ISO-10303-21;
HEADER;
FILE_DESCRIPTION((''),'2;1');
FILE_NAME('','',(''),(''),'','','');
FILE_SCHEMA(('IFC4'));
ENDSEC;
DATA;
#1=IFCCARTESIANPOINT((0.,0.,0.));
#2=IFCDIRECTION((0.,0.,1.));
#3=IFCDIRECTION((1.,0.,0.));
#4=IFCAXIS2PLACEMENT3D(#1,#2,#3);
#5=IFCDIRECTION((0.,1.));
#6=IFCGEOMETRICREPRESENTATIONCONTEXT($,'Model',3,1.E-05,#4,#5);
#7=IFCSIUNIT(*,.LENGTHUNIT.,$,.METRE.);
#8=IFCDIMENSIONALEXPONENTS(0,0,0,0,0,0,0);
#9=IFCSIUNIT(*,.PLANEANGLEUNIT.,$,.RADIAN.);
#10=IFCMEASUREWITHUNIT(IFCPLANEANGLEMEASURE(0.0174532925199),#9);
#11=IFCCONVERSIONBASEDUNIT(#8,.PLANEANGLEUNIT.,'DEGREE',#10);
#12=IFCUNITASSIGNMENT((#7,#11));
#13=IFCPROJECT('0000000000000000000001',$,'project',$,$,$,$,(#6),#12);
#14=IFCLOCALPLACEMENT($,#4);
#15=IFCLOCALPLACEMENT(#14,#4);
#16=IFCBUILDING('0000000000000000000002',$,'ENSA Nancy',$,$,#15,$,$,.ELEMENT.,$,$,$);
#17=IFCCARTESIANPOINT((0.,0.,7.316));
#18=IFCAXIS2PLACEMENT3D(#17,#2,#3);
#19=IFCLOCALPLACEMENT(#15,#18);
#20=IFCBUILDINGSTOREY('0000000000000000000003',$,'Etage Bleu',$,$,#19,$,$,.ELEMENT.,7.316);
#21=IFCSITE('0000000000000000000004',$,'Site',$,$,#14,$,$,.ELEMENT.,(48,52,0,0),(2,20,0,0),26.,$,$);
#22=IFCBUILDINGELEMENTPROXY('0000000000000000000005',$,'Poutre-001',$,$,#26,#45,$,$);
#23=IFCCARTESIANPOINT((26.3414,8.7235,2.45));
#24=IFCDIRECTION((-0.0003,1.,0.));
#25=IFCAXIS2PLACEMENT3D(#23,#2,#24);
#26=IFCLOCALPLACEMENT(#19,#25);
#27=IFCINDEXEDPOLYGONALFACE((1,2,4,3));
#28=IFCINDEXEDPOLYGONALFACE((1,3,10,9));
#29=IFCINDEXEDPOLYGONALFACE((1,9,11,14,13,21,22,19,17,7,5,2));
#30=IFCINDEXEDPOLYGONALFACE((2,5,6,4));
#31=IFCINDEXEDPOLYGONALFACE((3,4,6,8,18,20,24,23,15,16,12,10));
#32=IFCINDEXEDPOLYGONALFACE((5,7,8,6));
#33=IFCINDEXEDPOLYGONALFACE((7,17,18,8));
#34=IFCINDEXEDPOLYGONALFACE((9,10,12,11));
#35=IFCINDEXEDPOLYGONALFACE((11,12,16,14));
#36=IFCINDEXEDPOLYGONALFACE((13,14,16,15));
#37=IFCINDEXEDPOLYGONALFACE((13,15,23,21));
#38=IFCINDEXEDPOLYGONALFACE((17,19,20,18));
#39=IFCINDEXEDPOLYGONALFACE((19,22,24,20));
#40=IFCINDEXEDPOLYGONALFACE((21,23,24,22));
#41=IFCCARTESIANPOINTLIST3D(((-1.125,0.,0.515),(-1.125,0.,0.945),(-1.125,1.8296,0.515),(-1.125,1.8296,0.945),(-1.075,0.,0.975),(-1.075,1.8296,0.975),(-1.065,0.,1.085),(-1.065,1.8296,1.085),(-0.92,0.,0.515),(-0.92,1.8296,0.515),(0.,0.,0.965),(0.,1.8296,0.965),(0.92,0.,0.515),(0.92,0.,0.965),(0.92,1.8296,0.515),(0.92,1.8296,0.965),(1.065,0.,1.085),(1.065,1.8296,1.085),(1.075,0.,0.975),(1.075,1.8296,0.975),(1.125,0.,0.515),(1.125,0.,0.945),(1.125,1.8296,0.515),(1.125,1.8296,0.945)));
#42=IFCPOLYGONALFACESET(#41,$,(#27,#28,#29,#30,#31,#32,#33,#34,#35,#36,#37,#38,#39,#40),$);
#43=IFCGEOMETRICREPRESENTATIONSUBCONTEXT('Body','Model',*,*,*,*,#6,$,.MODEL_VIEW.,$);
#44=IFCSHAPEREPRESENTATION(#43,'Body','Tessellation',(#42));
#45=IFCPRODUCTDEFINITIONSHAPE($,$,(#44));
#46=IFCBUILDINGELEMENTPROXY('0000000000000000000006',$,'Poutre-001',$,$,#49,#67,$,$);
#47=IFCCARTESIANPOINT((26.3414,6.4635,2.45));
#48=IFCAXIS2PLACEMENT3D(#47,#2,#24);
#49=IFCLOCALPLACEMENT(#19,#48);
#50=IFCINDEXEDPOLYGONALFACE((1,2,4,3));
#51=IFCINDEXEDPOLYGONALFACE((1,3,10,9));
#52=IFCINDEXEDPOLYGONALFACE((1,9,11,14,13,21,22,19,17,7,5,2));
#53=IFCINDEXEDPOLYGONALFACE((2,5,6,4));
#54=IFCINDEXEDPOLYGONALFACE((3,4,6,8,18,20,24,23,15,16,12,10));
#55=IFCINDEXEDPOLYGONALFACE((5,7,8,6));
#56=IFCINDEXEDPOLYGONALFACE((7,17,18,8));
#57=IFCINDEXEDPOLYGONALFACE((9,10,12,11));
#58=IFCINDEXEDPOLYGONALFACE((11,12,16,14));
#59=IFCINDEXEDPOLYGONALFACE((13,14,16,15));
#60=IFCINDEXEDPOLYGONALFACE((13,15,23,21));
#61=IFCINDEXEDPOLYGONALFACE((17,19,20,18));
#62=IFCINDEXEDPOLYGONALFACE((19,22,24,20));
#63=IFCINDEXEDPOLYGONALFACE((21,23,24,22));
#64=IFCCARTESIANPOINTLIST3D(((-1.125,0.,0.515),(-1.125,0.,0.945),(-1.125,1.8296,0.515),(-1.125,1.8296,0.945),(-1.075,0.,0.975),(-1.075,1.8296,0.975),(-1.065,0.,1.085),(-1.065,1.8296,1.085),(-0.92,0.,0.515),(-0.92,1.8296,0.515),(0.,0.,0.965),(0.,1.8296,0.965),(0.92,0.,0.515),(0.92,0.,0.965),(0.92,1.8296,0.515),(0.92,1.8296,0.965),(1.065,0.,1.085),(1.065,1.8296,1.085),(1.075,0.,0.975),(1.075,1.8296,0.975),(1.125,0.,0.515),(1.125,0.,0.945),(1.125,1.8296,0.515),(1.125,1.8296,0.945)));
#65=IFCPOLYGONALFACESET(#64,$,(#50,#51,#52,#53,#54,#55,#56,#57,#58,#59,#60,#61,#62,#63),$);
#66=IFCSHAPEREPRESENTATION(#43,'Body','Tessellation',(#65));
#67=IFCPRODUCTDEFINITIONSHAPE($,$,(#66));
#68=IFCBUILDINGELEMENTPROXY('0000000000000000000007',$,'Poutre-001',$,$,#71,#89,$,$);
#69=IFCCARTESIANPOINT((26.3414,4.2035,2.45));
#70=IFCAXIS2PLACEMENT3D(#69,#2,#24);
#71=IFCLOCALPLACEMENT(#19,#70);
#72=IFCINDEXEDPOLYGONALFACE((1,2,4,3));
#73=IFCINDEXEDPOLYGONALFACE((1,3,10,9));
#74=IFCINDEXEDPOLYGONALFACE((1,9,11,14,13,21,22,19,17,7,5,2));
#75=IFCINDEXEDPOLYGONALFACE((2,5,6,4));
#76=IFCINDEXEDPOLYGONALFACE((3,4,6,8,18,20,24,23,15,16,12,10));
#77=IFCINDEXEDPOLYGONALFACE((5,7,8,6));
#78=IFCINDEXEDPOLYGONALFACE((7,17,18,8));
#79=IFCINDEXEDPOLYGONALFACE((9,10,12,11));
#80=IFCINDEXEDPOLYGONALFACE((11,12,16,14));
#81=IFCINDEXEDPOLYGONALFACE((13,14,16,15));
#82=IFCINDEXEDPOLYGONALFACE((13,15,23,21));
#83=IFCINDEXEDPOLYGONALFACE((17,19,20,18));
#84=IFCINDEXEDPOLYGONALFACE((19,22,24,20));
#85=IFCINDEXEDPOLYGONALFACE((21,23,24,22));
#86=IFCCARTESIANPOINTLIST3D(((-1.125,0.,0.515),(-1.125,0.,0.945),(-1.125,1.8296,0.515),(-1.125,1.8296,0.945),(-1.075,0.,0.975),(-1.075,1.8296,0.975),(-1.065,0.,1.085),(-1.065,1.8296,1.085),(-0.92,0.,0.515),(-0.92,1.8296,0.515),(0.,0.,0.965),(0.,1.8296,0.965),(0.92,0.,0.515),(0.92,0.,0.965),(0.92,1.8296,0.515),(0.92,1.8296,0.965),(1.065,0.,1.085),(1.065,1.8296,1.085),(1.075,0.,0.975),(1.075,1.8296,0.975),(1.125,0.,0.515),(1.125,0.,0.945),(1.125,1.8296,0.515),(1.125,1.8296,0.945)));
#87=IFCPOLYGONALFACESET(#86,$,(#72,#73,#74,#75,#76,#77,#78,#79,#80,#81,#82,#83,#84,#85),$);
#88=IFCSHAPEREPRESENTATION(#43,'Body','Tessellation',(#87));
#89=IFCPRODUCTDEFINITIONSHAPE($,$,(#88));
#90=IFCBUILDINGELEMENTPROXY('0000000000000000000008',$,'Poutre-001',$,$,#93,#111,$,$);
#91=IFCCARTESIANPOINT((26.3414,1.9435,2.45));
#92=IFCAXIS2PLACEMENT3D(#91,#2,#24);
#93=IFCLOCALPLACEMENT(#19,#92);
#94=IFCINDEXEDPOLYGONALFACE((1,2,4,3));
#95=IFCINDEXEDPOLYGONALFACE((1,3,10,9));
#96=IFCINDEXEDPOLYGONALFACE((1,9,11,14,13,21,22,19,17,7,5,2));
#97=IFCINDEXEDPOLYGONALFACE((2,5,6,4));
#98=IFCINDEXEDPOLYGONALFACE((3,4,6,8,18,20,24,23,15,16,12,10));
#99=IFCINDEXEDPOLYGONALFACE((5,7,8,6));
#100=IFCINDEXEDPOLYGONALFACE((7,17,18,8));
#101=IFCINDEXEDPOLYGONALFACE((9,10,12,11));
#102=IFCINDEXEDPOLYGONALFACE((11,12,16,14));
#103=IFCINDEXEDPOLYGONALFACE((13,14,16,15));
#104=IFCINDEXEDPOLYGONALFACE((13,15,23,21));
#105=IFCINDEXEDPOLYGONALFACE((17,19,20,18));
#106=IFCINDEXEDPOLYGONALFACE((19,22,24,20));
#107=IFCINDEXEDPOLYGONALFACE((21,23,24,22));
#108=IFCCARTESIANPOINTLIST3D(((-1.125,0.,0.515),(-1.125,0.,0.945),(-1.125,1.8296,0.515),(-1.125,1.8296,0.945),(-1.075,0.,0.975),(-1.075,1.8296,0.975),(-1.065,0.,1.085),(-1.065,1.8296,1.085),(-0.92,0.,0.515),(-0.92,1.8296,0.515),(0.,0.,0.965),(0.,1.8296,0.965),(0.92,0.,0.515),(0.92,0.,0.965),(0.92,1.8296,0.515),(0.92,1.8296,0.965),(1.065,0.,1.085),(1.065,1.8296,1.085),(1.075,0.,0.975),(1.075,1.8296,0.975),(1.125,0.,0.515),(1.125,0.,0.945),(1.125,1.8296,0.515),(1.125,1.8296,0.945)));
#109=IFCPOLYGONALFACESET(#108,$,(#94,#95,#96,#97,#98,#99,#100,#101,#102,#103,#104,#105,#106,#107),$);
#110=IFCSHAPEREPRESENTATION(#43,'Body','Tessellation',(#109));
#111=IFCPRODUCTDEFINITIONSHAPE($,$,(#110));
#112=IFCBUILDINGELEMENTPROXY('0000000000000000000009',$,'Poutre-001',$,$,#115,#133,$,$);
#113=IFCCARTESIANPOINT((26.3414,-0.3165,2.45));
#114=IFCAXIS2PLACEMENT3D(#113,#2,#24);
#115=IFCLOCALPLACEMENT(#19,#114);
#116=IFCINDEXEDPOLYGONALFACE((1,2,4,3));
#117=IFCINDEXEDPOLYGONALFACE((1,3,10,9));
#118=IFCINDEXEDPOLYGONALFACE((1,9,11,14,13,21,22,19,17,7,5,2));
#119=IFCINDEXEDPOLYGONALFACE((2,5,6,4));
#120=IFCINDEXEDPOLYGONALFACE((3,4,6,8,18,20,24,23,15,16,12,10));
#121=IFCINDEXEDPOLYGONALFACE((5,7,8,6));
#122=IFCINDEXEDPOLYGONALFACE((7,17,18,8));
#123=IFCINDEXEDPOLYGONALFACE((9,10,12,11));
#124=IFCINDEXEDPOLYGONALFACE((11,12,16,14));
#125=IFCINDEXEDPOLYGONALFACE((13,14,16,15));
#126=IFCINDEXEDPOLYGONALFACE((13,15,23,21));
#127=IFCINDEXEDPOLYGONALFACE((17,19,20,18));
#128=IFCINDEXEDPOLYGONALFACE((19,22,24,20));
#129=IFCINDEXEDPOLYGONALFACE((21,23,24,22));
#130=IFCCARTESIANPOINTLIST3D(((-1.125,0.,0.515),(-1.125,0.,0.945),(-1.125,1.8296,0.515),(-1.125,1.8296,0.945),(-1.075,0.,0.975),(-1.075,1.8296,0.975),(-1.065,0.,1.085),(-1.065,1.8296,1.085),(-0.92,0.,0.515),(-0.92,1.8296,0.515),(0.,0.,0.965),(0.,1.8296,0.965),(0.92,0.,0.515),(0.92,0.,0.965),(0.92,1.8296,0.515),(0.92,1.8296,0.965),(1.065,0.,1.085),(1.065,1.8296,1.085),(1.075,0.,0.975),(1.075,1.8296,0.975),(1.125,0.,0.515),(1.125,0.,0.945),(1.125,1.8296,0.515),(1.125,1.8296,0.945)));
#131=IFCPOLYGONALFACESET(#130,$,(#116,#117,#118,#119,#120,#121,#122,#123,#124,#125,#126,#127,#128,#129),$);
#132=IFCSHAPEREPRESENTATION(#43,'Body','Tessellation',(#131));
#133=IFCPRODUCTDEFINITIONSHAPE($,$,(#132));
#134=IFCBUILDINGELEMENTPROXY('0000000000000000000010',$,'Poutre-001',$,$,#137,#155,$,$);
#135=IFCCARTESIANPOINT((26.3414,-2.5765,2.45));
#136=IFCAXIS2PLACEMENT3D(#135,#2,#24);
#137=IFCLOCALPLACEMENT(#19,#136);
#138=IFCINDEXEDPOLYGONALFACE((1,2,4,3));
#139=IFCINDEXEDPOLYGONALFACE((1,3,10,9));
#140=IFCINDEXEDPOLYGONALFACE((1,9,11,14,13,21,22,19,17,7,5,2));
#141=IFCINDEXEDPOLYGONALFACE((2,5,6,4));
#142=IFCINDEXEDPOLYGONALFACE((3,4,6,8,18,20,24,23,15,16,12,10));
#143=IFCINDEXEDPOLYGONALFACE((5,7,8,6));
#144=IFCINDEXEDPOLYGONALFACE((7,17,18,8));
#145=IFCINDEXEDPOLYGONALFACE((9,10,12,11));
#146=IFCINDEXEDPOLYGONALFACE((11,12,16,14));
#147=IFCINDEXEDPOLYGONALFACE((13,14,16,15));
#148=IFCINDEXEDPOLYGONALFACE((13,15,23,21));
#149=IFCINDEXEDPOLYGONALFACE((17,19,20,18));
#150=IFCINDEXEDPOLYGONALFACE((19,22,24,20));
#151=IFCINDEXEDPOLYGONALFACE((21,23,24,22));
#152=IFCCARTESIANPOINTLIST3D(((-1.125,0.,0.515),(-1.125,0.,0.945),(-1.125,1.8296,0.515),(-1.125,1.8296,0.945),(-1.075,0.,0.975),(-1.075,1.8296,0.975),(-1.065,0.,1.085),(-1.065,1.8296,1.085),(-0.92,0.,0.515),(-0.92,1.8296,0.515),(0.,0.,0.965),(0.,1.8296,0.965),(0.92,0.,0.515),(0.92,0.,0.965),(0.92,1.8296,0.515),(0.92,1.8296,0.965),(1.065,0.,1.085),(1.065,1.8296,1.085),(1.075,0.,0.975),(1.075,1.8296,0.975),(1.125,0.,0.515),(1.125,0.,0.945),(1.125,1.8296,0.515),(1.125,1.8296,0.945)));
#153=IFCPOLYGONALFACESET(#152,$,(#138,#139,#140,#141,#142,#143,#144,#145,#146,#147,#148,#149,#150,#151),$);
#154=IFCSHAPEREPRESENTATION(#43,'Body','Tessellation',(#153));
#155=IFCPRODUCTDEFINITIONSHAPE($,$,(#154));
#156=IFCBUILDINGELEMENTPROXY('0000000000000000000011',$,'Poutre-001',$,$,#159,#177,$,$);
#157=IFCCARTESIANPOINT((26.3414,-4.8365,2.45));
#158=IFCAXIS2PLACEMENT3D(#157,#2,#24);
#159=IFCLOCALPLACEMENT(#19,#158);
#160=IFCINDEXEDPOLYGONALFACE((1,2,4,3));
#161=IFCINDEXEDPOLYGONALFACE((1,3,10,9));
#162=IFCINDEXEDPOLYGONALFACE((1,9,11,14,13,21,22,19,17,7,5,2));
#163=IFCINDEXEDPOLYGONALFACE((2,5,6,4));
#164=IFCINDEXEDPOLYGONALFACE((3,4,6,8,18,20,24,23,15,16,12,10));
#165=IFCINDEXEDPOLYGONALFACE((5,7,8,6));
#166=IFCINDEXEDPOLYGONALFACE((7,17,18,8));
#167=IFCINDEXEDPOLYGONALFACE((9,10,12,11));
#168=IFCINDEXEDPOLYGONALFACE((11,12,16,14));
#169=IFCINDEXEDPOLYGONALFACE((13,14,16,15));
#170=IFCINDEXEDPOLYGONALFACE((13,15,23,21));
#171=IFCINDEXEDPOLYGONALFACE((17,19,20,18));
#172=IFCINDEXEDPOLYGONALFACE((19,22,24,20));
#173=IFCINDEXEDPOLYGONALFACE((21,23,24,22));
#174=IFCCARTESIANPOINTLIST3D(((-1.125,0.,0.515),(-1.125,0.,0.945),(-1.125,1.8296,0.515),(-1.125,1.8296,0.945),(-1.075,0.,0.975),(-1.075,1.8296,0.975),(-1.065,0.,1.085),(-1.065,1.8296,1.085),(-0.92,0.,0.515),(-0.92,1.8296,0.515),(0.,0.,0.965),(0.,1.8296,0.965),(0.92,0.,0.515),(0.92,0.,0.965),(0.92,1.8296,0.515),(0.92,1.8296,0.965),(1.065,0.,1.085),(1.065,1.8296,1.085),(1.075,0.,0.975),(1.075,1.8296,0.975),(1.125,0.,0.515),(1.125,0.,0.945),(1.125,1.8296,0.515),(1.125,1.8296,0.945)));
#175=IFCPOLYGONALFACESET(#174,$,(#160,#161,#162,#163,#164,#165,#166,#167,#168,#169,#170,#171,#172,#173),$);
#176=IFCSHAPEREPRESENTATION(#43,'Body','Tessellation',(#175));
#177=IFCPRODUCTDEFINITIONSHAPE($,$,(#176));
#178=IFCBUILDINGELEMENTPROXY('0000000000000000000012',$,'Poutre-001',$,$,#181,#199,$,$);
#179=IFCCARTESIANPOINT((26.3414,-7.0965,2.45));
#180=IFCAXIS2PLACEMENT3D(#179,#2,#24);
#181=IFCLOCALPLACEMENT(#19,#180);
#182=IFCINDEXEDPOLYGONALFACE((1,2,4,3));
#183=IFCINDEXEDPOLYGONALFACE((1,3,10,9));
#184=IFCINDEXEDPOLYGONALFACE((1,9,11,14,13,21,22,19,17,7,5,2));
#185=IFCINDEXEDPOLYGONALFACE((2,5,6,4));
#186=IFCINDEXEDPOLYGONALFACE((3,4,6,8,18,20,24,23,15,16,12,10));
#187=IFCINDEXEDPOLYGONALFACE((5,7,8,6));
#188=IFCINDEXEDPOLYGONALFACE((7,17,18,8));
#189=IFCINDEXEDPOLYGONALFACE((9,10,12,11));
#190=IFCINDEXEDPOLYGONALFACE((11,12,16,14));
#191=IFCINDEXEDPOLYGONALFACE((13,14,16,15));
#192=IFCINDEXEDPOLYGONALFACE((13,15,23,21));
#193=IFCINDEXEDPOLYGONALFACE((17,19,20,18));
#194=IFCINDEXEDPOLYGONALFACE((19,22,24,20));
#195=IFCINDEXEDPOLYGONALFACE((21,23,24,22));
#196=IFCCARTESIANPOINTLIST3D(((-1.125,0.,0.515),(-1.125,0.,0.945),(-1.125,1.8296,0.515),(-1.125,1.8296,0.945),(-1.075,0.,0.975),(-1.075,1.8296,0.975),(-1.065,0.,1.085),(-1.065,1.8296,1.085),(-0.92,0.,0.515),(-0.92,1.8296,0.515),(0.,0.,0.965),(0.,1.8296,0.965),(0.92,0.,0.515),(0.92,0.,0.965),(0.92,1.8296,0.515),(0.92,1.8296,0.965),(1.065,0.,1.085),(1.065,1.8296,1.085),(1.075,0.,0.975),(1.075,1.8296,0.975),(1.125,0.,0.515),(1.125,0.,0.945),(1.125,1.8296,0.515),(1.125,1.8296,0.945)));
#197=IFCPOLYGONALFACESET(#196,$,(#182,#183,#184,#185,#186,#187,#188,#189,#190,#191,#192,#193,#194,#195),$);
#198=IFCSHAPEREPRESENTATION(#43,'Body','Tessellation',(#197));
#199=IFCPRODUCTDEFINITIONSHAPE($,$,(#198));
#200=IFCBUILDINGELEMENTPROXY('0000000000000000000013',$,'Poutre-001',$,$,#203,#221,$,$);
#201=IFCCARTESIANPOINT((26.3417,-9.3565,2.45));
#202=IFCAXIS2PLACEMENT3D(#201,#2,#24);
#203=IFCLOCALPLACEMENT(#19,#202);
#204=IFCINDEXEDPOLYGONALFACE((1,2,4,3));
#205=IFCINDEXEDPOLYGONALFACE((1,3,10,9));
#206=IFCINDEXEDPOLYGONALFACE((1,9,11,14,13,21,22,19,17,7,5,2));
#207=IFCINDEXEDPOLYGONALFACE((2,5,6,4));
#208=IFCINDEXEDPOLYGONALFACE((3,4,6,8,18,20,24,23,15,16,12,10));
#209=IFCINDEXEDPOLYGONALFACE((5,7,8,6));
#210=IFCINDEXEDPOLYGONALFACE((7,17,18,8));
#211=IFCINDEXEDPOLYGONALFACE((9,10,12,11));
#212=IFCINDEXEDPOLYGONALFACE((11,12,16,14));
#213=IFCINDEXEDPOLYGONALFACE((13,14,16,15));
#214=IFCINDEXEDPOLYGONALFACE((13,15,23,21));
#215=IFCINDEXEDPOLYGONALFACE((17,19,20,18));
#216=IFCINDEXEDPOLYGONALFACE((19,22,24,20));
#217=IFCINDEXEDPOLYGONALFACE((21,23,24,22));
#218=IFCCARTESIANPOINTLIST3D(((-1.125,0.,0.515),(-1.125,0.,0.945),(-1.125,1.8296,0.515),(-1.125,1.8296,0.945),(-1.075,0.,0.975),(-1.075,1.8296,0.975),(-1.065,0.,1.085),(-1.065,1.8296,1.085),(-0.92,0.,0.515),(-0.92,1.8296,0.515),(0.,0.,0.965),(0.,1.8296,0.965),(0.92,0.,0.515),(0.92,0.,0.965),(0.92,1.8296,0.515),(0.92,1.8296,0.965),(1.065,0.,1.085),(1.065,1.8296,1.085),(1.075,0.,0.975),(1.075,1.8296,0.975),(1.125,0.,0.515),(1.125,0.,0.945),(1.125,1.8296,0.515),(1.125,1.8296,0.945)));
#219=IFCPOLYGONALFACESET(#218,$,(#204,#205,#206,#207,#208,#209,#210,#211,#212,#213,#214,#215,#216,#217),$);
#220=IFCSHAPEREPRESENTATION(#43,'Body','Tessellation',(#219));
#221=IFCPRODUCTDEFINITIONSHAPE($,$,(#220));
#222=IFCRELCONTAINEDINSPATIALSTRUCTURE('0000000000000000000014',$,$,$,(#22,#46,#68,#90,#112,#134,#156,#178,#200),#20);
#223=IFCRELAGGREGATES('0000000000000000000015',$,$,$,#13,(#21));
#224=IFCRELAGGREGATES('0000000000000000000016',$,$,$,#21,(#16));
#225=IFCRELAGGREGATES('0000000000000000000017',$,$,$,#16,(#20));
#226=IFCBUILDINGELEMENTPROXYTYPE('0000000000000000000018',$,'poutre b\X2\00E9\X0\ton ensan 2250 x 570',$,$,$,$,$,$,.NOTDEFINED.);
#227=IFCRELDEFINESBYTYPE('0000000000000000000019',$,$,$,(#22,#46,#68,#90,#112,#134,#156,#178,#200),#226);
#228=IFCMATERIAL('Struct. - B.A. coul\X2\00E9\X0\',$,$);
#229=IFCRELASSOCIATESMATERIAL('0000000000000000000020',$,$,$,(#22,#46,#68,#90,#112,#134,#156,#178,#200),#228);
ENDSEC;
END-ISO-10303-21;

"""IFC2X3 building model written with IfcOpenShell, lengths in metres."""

from ifc_helpers import new_model, entity, si_unit, converted_unit, direction, frame, origin_with_axes, place, context, subcontext, project, spatial, polyline, outline, extrude, material, type_object, element, save


model = new_model("IFC2X3")

# Units and contexts
model_context = context("Model", 3, precision=1e-05, world=origin_with_axes(), true_north=direction((0.0, 1.0)))
body_context = subcontext(model_context, "Body", "Model", "MODEL_VIEW")
ifc_project = project(units=[si_unit("LENGTHUNIT", "METRE"), converted_unit("PLANEANGLEUNIT", "DEGREE", entity("IfcPlaneAngleMeasure", 0.0174532925199), si_unit("PLANEANGLEUNIT", "RADIAN"), dimensions=[0, 0, 0, 0, 0, 0, 0])], contexts=[model_context])

# Site, building, storey
site_placement = place(None, origin_with_axes())
site = spatial("IfcSite", under=ifc_project, at=site_placement, Name="Site", CompositionType="ELEMENT", RefLatitude=(48, 52, 0, 0), RefLongitude=(2, 20, 0, 0), RefElevation=26.0)
building_placement = place(site_placement, origin_with_axes())
building = spatial("IfcBuilding", under=site, at=building_placement, Name="ENSA Nancy", CompositionType="ELEMENT")
storey_placement = place(building_placement, frame((0.0, 0.0, 7.316), z_axis=(0.0, 0.0, 1.0), x_axis=(1.0, 0.0, 0.0)))
storey = spatial("IfcBuildingStorey", under=building, at=storey_placement, Name="Etage Bleu", CompositionType="ELEMENT", Elevation=7.316)

# Building element proxies
ifc_material_1 = material(Name="Struct. - B.A. coulé")
building_element_proxy_type_1 = type_object("IfcBuildingElementProxyType", Name="poutre béton ensan 2250 x 570", PredefinedType="NOTDEFINED")
for number, where, z_axis, x_axis, name in (
    (1, (26.3414, 8.7235, 2.45), (0.0, 0.0, 1.0), (-0.0003, 1.0, 0.0), "Poutre-001"),
    (2, (26.3414, 6.4635, 2.45), (0.0, 0.0, 1.0), (-0.0003, 1.0, 0.0), "Poutre-001"),
    (3, (26.3414, 4.2035, 2.45), (0.0, 0.0, 1.0), (-0.0003, 1.0, 0.0), "Poutre-001"),
    (4, (26.3414, 1.9435, 2.45), (0.0, 0.0, 1.0), (-0.0003, 1.0, 0.0), "Poutre-001"),
    (5, (26.3414, -0.3165, 2.45), (0.0, 0.0, 1.0), (-0.0003, 1.0, 0.0), "Poutre-001"),
    (6, (26.3414, -2.5765, 2.45), (0.0, 0.0, 1.0), (-0.0003, 1.0, 0.0), "Poutre-001"),
    (7, (26.3414, -4.8365, 2.45), (0.0, 0.0, 1.0), (-0.0003, 1.0, 0.0), "Poutre-001"),
    (8, (26.3414, -7.0965, 2.45), (0.0, 0.0, 1.0), (-0.0003, 1.0, 0.0), "Poutre-001"),
    (9, (26.3417, -9.3565, 2.45), (0.0, 0.0, 1.0), (-0.0003, 1.0, 0.0), "Poutre-001"),
):
    element("IfcBuildingElementProxy", number, at=place(storey_placement, frame(where, z_axis=z_axis, x_axis=x_axis)), inside=storey, type_object=building_element_proxy_type_1, material=ifc_material_1, Name=name, context=body_context, shape_type="SweptSolid", body=[
        extrude(outline(polyline([(-1.065, 1.085), (-1.075, 0.975), (-1.125, 0.945), (-1.125, 0.515), (-0.92, 0.515), (0.0, 0.965), (0.92, 0.965), (0.92, 0.515), (1.125, 0.515), (1.125, 0.945), (1.075, 0.975), (1.065, 1.085), (-1.065, 1.085)])), frame((0.0, 1.8296, 0.0), z_axis=(0.0, -1.0, 0.0), x_axis=(1.0, 0.0, 0.0)), (0.0, 0.0, 1.0), 1.8296),
    ])

save(model, "model.ifc")
